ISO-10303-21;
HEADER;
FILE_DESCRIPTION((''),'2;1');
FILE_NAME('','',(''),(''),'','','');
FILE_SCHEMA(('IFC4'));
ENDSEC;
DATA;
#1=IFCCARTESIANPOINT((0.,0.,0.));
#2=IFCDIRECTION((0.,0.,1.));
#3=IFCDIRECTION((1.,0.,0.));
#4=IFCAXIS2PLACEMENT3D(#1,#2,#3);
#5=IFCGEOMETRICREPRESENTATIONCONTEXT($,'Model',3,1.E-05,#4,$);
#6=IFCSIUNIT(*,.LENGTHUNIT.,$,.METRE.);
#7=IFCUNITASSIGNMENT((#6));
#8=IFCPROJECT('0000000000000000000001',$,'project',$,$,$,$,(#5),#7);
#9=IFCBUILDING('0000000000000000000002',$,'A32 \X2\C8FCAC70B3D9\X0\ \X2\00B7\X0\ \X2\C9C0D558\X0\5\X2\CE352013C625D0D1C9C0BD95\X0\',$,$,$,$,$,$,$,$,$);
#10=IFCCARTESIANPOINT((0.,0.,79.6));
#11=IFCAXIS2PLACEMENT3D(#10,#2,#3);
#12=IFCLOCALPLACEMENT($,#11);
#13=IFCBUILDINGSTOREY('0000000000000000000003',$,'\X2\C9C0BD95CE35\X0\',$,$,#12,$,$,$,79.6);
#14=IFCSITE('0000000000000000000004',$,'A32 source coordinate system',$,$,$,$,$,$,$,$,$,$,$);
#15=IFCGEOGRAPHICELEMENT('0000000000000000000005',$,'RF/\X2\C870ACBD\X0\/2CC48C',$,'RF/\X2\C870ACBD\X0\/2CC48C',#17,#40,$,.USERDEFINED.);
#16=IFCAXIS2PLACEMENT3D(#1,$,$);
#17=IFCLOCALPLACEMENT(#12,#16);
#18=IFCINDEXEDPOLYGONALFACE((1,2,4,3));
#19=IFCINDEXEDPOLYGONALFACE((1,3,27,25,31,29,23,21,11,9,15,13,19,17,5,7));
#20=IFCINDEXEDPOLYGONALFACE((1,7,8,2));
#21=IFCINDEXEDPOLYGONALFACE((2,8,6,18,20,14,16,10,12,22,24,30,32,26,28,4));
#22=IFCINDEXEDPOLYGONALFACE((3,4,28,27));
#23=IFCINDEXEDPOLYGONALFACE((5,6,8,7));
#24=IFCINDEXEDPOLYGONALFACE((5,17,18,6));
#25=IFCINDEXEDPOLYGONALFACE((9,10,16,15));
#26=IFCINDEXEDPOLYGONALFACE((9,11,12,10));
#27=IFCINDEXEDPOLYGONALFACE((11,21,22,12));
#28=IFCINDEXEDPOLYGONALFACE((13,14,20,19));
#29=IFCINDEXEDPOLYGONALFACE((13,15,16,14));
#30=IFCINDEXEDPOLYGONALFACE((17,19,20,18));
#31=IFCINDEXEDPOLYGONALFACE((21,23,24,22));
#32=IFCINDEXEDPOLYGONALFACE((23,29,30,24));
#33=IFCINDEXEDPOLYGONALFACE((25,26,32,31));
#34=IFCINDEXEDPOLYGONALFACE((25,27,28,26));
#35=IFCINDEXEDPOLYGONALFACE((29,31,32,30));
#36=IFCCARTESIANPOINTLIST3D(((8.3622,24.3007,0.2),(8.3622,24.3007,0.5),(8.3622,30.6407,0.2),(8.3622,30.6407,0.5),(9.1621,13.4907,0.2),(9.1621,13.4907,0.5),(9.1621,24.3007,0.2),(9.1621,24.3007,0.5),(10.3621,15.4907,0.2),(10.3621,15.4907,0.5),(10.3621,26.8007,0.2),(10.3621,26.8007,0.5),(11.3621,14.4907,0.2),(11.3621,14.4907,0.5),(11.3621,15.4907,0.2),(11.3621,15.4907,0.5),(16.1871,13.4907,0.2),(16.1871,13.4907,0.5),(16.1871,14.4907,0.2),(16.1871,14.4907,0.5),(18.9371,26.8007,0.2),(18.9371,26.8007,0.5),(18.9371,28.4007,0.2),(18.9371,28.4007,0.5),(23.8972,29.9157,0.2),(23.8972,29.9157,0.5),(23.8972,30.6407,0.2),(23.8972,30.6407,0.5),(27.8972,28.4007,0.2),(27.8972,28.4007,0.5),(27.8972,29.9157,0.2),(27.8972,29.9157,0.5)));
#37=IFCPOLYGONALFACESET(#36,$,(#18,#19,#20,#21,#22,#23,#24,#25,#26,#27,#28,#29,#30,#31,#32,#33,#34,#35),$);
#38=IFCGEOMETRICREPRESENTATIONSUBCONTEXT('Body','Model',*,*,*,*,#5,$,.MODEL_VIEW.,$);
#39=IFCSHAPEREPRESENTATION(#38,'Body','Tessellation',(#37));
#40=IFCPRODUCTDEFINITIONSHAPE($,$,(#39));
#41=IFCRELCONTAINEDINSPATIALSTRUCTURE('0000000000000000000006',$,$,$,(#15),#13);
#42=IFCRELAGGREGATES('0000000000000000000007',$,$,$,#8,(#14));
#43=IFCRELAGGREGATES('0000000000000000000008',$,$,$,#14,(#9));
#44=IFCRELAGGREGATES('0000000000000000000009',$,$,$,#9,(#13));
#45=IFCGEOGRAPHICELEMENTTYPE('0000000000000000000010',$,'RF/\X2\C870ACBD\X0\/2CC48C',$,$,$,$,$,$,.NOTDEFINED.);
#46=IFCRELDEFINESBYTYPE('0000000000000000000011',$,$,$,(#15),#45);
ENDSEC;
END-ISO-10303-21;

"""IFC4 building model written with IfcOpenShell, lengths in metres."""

from ifc_helpers import new_model, si_unit, frame, origin, origin_with_axes, place, context, subcontext, project, spatial, polyline, outline, extrude, source, transform, mapped, type_object, type_shapes, element, save


model = new_model("IFC4")

# Units and contexts
model_context = context("Model", 3, precision=1e-05, world=origin_with_axes())
body_context = subcontext(model_context, "Body", "Model", "MODEL_VIEW")
ifc_project = project(units=[si_unit("LENGTHUNIT", "METRE")], contexts=[model_context])

# Site, building, storey
site = spatial("IfcSite", under=ifc_project, Name="A32 source coordinate system")
building = spatial("IfcBuilding", under=site, Name="A32 주거동 · 지하5층–옥탑지붕")
storey_placement = place(None, frame((0.0, 0.0, 79.6), z_axis=(0.0, 0.0, 1.0), x_axis=(1.0, 0.0, 0.0)))
storey = spatial("IfcBuildingStorey", under=building, at=storey_placement, Name="지붕층", Elevation=79.6)

# Geographic element
geographic_element_type_1 = type_object("IfcGeographicElementType", Name="RF/조경/2CC48C", PredefinedType="NOTDEFINED")
shared_shape_1 = source(origin(), body_context, "Body", "SweptSolid", [
    extrude(outline(polyline([(18.9371, 26.8007), (10.3621, 26.8007), (10.3621, 15.4907), (11.3621, 15.4907), (11.3621, 14.4907), (16.1871, 14.4907), (16.1871, 13.4907), (9.1621, 13.4907), (9.1621, 24.3007), (8.3622, 24.3007), (8.3622, 30.6407), (23.8972, 30.6407), (23.8972, 29.9157), (27.8972, 29.9157), (27.8972, 28.4007), (18.9371, 28.4007), (18.9371, 26.8007)])), frame((0.0, 0.0, 0.2)), (0.0, 0.0, 1.0), 0.3),
])
type_shapes(geographic_element_type_1, [shared_shape_1])
geographic_element_1_placement = place(storey_placement, origin_with_axes())
element("IfcGeographicElement", 1, at=geographic_element_1_placement, inside=storey, type_object=geographic_element_type_1, Name="RF/조경/2CC48C", ObjectType="RF/조경/2CC48C", PredefinedType="USERDEFINED", context=body_context, shape_type="MappedRepresentation", body=[
    mapped(shared_shape_1, transform((0.0, 0.0, 0.0), scale=1.0)),
])

save(model, "model.ifc")
